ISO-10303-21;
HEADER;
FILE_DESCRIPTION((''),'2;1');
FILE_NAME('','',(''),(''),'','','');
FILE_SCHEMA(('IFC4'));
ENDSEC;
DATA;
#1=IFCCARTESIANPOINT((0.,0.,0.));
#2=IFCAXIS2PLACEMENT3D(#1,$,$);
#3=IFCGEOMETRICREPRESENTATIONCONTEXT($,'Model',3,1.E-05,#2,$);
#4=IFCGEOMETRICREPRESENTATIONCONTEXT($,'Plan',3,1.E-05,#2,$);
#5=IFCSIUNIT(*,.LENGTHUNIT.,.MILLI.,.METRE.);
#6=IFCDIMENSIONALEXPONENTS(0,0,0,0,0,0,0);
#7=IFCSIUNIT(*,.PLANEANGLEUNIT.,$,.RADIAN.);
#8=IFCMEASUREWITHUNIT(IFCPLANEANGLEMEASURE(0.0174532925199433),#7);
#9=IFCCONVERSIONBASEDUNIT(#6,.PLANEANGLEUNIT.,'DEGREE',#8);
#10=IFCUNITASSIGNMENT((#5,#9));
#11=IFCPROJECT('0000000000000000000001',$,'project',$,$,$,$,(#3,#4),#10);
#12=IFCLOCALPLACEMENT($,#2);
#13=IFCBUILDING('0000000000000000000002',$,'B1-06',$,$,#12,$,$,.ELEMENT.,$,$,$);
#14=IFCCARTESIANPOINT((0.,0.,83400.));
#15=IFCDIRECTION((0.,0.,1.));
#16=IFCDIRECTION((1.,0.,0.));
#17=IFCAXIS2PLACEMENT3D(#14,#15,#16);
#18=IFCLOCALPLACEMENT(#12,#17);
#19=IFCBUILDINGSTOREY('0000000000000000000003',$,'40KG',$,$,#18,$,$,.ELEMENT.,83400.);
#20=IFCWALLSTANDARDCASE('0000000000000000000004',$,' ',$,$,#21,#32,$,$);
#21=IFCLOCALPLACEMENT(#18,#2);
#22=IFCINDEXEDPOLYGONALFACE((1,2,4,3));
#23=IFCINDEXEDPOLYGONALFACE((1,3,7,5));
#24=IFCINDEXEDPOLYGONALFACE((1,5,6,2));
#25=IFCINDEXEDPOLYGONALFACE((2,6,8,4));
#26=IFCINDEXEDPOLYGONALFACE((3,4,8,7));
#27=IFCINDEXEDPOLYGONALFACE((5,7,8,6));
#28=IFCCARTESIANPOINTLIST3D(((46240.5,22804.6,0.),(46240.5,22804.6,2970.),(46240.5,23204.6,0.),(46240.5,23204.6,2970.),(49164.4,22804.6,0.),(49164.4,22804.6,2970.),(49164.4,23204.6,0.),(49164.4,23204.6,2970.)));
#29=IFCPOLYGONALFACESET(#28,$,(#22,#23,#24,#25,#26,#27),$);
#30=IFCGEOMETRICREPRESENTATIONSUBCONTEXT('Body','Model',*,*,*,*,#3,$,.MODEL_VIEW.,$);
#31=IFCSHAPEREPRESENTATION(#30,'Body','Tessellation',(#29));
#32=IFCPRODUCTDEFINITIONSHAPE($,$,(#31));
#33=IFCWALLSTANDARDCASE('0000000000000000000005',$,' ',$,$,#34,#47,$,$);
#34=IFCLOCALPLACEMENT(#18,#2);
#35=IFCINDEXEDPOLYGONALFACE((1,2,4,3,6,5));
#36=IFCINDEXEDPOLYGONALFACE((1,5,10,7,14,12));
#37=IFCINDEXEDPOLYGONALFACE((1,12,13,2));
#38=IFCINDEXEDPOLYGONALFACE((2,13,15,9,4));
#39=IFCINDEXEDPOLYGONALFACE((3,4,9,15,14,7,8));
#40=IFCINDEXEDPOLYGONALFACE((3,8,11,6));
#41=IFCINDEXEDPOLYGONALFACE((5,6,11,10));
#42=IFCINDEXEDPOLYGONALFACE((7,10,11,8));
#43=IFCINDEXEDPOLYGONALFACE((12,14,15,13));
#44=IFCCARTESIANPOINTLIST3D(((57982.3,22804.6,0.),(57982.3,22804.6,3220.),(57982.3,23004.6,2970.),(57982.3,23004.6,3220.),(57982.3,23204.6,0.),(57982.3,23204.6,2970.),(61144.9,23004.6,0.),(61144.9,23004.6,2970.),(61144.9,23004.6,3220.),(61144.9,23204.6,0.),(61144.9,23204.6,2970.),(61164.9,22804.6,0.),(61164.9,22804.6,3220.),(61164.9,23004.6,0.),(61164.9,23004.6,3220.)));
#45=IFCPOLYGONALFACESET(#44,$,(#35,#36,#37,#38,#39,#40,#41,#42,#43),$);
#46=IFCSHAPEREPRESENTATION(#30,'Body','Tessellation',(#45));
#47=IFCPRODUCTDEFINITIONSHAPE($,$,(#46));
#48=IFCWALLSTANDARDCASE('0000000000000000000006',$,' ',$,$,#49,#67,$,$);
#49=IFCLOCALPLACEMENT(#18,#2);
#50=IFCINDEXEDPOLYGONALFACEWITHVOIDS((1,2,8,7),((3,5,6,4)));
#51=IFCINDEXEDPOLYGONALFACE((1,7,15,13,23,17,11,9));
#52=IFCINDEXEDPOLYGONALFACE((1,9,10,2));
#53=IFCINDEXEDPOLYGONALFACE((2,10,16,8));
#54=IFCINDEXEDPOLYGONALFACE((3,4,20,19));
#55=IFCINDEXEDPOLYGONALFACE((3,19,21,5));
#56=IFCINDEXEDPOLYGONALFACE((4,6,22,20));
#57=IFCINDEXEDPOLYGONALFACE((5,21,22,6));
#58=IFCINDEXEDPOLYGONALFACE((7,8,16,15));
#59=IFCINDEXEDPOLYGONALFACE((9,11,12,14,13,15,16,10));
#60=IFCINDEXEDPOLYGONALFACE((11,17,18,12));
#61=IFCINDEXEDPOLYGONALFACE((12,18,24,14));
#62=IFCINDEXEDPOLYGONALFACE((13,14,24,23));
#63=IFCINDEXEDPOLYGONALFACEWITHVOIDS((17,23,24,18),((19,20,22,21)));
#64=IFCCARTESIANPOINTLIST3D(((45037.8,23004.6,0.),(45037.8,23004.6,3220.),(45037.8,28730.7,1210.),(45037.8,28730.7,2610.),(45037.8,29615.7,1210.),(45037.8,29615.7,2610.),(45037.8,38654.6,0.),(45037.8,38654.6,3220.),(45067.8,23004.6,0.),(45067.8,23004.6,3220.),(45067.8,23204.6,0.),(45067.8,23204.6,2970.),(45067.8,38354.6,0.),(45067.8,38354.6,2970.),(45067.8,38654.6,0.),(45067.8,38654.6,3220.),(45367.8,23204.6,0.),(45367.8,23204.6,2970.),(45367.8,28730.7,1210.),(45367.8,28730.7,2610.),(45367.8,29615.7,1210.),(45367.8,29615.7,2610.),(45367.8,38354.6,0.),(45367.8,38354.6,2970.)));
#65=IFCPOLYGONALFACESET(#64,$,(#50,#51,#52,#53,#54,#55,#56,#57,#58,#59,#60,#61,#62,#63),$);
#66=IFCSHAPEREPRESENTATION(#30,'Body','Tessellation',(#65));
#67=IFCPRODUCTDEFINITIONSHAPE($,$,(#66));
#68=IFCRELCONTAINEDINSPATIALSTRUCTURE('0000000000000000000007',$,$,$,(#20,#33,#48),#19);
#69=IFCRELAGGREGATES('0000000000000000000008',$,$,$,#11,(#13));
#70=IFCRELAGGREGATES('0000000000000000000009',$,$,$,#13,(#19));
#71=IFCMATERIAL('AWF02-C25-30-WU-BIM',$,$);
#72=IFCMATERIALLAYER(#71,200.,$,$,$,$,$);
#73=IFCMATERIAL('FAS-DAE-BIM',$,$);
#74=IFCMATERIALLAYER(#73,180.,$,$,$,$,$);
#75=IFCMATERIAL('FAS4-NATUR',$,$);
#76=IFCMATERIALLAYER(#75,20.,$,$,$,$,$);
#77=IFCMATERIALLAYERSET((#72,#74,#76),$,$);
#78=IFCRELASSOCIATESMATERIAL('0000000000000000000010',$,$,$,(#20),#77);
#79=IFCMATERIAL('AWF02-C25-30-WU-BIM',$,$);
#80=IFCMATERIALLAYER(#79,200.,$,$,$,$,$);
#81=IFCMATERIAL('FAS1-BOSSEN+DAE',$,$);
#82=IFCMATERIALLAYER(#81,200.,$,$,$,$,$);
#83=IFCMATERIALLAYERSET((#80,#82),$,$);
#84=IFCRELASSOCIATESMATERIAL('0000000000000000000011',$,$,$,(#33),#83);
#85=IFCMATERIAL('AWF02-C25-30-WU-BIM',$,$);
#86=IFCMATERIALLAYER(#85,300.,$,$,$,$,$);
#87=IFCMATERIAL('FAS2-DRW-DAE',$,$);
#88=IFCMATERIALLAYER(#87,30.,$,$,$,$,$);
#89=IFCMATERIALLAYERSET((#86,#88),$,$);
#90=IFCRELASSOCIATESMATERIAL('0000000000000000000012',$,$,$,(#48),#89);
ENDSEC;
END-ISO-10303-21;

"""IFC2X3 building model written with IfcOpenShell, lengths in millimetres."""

from ifc_helpers import new_model, entity, si_unit, converted_unit, frame, frame_2d, origin, origin_with_axes, place, context, subcontext, project, spatial, polyline, rectangle, outline, extrude, clip, bounded_halfspace, material, layer, layer_set, layer_usage, element, save


model = new_model("IFC2X3")

# Units and contexts
model_context = context("Model", 3, precision=1e-05, world=origin())
plan_context = context("Plan", 3, precision=1e-05, world=origin())
body_context = subcontext(model_context, "Body", "Model", "MODEL_VIEW")
ifc_project = project(units=[si_unit("LENGTHUNIT", "METRE", prefix="MILLI"), converted_unit("PLANEANGLEUNIT", "DEGREE", entity("IfcPlaneAngleMeasure", 0.0174532925199433), si_unit("PLANEANGLEUNIT", "RADIAN"), dimensions=[0, 0, 0, 0, 0, 0, 0])], contexts=[model_context, plan_context])

# Building, storey
building_placement = place(None, origin())
building = spatial("IfcBuilding", under=ifc_project, at=building_placement, Name="B1-06", CompositionType="ELEMENT")
storey_placement = place(building_placement, frame((0.0, 0.0, 83400.0), z_axis=(0.0, 0.0, 1.0), x_axis=(1.0, 0.0, 0.0)))
storey = spatial("IfcBuildingStorey", under=building, at=storey_placement, Name="40KG", CompositionType="ELEMENT", Elevation=83400.0)

# Walls
ifc_material_1 = material(Name="AWF02-C25-30-WU-BIM")
ifc_layer_1 = layer(ifc_material_1, 200.0)
ifc_material_2 = material(Name="FAS-DAE-BIM")
ifc_layer_2 = layer(ifc_material_2, 180.0)
ifc_material_3 = material(Name="FAS4-NATUR")
ifc_layer_3 = layer(ifc_material_3, 20.0)
ifc_layer_set_1 = layer_set([ifc_layer_1, ifc_layer_2, ifc_layer_3])
ifc_layer_usage_1 = layer_usage(ifc_layer_set_1, "AXIS2", "POSITIVE", 0.0)
wall_1_placement = place(storey_placement, frame((49164.4, 23204.6, 0.0), z_axis=(0.0, 0.0, 1.0), x_axis=(-1.0, 0.0, 0.0)))
element("IfcWallStandardCase", 1, at=wall_1_placement, inside=storey, material=ifc_layer_usage_1, Name=" ", context=body_context, shape_type="SweptSolid", body=[
    extrude(rectangle(XDim=2923.9, YDim=400.0, at=frame_2d((1461.9, 200.0), x_axis=(1.0, 0.0))), origin_with_axes(), (0.0, 0.0, 1.0), 2970.0),
])
ifc_material_4 = material(Name="AWF02-C25-30-WU-BIM")
ifc_layer_4 = layer(ifc_material_4, 200.0)
ifc_material_5 = material(Name="FAS1-BOSSEN+DAE")
ifc_layer_5 = layer(ifc_material_5, 200.0)
ifc_layer_set_2 = layer_set([ifc_layer_4, ifc_layer_5])
ifc_layer_usage_2 = layer_usage(ifc_layer_set_2, "AXIS2", "POSITIVE", 0.0)
wall_2_placement = place(storey_placement, frame((61144.9, 23204.6, 0.0), z_axis=(0.0, 0.0, 1.0), x_axis=(-1.0, 0.0, 0.0)))
element("IfcWallStandardCase", 2, at=wall_2_placement, inside=storey, material=ifc_layer_usage_2, Name=" ", context=body_context, shape_type="Clipping", body=[
    clip(clip(extrude(outline(polyline([(-20.0, 400.0), (-20.0, 200.0), (0.0, 200.0), (0.0, 0.0), (3162.6, 0.0), (3162.6, 400.0), (-20.0, 400.0)])), origin_with_axes(), (0.0, 0.0, 1.0), 3220.0), bounded_halfspace(frame((0.0, 0.0, 2970.0), z_axis=(0.0, 0.0, -1.0), x_axis=(1.0, 0.0, 0.0)), True, origin(), polyline([(0.0, 0.0), (3162.6, 0.0), (3162.6, 200.0), (0.0, 200.0), (0.0, 0.0)]))), bounded_halfspace(frame((-20.0, 200.0, 3220.0), z_axis=(0.0, 0.0, -1.0), x_axis=(1.0, 0.0, 0.0)), True, origin(), polyline([(-20.0, 200.0), (3162.6, 200.0), (3162.6, 400.0), (-20.0, 400.0), (-20.0, 200.0)]))),
])

# Wall, opening
ifc_material_6 = material(Name="AWF02-C25-30-WU-BIM")
ifc_layer_6 = layer(ifc_material_6, 300.0)
ifc_material_7 = material(Name="FAS2-DRW-DAE")
ifc_layer_7 = layer(ifc_material_7, 30.0)
ifc_layer_set_3 = layer_set([ifc_layer_6, ifc_layer_7])
ifc_layer_usage_3 = layer_usage(ifc_layer_set_3, "AXIS2", "POSITIVE", 0.0)
wall_3_placement = place(storey_placement, frame((45367.8, 23204.6, 0.0), z_axis=(0.0, 0.0, 1.0), x_axis=(0.0, 1.0, 0.0)))
wall_3 = element("IfcWallStandardCase", 3, at=wall_3_placement, inside=storey, material=ifc_layer_usage_3, Name=" ", context=body_context, shape_type="Clipping", body=[
    clip(clip(extrude(outline(polyline([(0.0, 0.0), (15150.0, 0.0), (15150.0, 300.0), (15450.0, 300.0), (15450.0, 330.0), (-200.0, 330.0), (-200.0, 300.0), (0.0, 300.0), (0.0, 0.0)])), origin_with_axes(), (0.0, 0.0, 1.0), 3220.0), bounded_halfspace(frame((0.0, 0.0, 2970.0), z_axis=(0.0, 0.0, -1.0), x_axis=(1.0, 0.0, 0.0)), True, origin(), polyline([(0.0, 0.0), (15150.0, 0.0), (15150.0, 300.0), (0.0, 300.0), (0.0, 0.0)]))), bounded_halfspace(frame((-200.0, 300.0, 3220.0), z_axis=(0.0, 0.0, -1.0), x_axis=(1.0, 0.0, 0.0)), True, origin(), polyline([(-200.0, 300.0), (15450.0, 300.0), (15450.0, 330.0), (-200.0, 330.0), (-200.0, 300.0)]))),
])
opening_1_placement = place(wall_3_placement, frame((5526.2, 0.0, 1210.0), z_axis=(0.0, 1.0, 0.0), x_axis=(0.0, 0.0, 1.0)))
element("IfcOpeningElement", 4, at=opening_1_placement, cuts=wall_3, ObjectType="Opening", context=body_context, shape_type="SweptSolid", body=[
    extrude(rectangle(XDim=1400.0, YDim=885.0, at=frame_2d((700.0, 442.5), x_axis=(1.0, 0.0))), origin_with_axes(), (0.0, 0.0, 1.0), 330.0),
])

save(model, "model.ifc")
